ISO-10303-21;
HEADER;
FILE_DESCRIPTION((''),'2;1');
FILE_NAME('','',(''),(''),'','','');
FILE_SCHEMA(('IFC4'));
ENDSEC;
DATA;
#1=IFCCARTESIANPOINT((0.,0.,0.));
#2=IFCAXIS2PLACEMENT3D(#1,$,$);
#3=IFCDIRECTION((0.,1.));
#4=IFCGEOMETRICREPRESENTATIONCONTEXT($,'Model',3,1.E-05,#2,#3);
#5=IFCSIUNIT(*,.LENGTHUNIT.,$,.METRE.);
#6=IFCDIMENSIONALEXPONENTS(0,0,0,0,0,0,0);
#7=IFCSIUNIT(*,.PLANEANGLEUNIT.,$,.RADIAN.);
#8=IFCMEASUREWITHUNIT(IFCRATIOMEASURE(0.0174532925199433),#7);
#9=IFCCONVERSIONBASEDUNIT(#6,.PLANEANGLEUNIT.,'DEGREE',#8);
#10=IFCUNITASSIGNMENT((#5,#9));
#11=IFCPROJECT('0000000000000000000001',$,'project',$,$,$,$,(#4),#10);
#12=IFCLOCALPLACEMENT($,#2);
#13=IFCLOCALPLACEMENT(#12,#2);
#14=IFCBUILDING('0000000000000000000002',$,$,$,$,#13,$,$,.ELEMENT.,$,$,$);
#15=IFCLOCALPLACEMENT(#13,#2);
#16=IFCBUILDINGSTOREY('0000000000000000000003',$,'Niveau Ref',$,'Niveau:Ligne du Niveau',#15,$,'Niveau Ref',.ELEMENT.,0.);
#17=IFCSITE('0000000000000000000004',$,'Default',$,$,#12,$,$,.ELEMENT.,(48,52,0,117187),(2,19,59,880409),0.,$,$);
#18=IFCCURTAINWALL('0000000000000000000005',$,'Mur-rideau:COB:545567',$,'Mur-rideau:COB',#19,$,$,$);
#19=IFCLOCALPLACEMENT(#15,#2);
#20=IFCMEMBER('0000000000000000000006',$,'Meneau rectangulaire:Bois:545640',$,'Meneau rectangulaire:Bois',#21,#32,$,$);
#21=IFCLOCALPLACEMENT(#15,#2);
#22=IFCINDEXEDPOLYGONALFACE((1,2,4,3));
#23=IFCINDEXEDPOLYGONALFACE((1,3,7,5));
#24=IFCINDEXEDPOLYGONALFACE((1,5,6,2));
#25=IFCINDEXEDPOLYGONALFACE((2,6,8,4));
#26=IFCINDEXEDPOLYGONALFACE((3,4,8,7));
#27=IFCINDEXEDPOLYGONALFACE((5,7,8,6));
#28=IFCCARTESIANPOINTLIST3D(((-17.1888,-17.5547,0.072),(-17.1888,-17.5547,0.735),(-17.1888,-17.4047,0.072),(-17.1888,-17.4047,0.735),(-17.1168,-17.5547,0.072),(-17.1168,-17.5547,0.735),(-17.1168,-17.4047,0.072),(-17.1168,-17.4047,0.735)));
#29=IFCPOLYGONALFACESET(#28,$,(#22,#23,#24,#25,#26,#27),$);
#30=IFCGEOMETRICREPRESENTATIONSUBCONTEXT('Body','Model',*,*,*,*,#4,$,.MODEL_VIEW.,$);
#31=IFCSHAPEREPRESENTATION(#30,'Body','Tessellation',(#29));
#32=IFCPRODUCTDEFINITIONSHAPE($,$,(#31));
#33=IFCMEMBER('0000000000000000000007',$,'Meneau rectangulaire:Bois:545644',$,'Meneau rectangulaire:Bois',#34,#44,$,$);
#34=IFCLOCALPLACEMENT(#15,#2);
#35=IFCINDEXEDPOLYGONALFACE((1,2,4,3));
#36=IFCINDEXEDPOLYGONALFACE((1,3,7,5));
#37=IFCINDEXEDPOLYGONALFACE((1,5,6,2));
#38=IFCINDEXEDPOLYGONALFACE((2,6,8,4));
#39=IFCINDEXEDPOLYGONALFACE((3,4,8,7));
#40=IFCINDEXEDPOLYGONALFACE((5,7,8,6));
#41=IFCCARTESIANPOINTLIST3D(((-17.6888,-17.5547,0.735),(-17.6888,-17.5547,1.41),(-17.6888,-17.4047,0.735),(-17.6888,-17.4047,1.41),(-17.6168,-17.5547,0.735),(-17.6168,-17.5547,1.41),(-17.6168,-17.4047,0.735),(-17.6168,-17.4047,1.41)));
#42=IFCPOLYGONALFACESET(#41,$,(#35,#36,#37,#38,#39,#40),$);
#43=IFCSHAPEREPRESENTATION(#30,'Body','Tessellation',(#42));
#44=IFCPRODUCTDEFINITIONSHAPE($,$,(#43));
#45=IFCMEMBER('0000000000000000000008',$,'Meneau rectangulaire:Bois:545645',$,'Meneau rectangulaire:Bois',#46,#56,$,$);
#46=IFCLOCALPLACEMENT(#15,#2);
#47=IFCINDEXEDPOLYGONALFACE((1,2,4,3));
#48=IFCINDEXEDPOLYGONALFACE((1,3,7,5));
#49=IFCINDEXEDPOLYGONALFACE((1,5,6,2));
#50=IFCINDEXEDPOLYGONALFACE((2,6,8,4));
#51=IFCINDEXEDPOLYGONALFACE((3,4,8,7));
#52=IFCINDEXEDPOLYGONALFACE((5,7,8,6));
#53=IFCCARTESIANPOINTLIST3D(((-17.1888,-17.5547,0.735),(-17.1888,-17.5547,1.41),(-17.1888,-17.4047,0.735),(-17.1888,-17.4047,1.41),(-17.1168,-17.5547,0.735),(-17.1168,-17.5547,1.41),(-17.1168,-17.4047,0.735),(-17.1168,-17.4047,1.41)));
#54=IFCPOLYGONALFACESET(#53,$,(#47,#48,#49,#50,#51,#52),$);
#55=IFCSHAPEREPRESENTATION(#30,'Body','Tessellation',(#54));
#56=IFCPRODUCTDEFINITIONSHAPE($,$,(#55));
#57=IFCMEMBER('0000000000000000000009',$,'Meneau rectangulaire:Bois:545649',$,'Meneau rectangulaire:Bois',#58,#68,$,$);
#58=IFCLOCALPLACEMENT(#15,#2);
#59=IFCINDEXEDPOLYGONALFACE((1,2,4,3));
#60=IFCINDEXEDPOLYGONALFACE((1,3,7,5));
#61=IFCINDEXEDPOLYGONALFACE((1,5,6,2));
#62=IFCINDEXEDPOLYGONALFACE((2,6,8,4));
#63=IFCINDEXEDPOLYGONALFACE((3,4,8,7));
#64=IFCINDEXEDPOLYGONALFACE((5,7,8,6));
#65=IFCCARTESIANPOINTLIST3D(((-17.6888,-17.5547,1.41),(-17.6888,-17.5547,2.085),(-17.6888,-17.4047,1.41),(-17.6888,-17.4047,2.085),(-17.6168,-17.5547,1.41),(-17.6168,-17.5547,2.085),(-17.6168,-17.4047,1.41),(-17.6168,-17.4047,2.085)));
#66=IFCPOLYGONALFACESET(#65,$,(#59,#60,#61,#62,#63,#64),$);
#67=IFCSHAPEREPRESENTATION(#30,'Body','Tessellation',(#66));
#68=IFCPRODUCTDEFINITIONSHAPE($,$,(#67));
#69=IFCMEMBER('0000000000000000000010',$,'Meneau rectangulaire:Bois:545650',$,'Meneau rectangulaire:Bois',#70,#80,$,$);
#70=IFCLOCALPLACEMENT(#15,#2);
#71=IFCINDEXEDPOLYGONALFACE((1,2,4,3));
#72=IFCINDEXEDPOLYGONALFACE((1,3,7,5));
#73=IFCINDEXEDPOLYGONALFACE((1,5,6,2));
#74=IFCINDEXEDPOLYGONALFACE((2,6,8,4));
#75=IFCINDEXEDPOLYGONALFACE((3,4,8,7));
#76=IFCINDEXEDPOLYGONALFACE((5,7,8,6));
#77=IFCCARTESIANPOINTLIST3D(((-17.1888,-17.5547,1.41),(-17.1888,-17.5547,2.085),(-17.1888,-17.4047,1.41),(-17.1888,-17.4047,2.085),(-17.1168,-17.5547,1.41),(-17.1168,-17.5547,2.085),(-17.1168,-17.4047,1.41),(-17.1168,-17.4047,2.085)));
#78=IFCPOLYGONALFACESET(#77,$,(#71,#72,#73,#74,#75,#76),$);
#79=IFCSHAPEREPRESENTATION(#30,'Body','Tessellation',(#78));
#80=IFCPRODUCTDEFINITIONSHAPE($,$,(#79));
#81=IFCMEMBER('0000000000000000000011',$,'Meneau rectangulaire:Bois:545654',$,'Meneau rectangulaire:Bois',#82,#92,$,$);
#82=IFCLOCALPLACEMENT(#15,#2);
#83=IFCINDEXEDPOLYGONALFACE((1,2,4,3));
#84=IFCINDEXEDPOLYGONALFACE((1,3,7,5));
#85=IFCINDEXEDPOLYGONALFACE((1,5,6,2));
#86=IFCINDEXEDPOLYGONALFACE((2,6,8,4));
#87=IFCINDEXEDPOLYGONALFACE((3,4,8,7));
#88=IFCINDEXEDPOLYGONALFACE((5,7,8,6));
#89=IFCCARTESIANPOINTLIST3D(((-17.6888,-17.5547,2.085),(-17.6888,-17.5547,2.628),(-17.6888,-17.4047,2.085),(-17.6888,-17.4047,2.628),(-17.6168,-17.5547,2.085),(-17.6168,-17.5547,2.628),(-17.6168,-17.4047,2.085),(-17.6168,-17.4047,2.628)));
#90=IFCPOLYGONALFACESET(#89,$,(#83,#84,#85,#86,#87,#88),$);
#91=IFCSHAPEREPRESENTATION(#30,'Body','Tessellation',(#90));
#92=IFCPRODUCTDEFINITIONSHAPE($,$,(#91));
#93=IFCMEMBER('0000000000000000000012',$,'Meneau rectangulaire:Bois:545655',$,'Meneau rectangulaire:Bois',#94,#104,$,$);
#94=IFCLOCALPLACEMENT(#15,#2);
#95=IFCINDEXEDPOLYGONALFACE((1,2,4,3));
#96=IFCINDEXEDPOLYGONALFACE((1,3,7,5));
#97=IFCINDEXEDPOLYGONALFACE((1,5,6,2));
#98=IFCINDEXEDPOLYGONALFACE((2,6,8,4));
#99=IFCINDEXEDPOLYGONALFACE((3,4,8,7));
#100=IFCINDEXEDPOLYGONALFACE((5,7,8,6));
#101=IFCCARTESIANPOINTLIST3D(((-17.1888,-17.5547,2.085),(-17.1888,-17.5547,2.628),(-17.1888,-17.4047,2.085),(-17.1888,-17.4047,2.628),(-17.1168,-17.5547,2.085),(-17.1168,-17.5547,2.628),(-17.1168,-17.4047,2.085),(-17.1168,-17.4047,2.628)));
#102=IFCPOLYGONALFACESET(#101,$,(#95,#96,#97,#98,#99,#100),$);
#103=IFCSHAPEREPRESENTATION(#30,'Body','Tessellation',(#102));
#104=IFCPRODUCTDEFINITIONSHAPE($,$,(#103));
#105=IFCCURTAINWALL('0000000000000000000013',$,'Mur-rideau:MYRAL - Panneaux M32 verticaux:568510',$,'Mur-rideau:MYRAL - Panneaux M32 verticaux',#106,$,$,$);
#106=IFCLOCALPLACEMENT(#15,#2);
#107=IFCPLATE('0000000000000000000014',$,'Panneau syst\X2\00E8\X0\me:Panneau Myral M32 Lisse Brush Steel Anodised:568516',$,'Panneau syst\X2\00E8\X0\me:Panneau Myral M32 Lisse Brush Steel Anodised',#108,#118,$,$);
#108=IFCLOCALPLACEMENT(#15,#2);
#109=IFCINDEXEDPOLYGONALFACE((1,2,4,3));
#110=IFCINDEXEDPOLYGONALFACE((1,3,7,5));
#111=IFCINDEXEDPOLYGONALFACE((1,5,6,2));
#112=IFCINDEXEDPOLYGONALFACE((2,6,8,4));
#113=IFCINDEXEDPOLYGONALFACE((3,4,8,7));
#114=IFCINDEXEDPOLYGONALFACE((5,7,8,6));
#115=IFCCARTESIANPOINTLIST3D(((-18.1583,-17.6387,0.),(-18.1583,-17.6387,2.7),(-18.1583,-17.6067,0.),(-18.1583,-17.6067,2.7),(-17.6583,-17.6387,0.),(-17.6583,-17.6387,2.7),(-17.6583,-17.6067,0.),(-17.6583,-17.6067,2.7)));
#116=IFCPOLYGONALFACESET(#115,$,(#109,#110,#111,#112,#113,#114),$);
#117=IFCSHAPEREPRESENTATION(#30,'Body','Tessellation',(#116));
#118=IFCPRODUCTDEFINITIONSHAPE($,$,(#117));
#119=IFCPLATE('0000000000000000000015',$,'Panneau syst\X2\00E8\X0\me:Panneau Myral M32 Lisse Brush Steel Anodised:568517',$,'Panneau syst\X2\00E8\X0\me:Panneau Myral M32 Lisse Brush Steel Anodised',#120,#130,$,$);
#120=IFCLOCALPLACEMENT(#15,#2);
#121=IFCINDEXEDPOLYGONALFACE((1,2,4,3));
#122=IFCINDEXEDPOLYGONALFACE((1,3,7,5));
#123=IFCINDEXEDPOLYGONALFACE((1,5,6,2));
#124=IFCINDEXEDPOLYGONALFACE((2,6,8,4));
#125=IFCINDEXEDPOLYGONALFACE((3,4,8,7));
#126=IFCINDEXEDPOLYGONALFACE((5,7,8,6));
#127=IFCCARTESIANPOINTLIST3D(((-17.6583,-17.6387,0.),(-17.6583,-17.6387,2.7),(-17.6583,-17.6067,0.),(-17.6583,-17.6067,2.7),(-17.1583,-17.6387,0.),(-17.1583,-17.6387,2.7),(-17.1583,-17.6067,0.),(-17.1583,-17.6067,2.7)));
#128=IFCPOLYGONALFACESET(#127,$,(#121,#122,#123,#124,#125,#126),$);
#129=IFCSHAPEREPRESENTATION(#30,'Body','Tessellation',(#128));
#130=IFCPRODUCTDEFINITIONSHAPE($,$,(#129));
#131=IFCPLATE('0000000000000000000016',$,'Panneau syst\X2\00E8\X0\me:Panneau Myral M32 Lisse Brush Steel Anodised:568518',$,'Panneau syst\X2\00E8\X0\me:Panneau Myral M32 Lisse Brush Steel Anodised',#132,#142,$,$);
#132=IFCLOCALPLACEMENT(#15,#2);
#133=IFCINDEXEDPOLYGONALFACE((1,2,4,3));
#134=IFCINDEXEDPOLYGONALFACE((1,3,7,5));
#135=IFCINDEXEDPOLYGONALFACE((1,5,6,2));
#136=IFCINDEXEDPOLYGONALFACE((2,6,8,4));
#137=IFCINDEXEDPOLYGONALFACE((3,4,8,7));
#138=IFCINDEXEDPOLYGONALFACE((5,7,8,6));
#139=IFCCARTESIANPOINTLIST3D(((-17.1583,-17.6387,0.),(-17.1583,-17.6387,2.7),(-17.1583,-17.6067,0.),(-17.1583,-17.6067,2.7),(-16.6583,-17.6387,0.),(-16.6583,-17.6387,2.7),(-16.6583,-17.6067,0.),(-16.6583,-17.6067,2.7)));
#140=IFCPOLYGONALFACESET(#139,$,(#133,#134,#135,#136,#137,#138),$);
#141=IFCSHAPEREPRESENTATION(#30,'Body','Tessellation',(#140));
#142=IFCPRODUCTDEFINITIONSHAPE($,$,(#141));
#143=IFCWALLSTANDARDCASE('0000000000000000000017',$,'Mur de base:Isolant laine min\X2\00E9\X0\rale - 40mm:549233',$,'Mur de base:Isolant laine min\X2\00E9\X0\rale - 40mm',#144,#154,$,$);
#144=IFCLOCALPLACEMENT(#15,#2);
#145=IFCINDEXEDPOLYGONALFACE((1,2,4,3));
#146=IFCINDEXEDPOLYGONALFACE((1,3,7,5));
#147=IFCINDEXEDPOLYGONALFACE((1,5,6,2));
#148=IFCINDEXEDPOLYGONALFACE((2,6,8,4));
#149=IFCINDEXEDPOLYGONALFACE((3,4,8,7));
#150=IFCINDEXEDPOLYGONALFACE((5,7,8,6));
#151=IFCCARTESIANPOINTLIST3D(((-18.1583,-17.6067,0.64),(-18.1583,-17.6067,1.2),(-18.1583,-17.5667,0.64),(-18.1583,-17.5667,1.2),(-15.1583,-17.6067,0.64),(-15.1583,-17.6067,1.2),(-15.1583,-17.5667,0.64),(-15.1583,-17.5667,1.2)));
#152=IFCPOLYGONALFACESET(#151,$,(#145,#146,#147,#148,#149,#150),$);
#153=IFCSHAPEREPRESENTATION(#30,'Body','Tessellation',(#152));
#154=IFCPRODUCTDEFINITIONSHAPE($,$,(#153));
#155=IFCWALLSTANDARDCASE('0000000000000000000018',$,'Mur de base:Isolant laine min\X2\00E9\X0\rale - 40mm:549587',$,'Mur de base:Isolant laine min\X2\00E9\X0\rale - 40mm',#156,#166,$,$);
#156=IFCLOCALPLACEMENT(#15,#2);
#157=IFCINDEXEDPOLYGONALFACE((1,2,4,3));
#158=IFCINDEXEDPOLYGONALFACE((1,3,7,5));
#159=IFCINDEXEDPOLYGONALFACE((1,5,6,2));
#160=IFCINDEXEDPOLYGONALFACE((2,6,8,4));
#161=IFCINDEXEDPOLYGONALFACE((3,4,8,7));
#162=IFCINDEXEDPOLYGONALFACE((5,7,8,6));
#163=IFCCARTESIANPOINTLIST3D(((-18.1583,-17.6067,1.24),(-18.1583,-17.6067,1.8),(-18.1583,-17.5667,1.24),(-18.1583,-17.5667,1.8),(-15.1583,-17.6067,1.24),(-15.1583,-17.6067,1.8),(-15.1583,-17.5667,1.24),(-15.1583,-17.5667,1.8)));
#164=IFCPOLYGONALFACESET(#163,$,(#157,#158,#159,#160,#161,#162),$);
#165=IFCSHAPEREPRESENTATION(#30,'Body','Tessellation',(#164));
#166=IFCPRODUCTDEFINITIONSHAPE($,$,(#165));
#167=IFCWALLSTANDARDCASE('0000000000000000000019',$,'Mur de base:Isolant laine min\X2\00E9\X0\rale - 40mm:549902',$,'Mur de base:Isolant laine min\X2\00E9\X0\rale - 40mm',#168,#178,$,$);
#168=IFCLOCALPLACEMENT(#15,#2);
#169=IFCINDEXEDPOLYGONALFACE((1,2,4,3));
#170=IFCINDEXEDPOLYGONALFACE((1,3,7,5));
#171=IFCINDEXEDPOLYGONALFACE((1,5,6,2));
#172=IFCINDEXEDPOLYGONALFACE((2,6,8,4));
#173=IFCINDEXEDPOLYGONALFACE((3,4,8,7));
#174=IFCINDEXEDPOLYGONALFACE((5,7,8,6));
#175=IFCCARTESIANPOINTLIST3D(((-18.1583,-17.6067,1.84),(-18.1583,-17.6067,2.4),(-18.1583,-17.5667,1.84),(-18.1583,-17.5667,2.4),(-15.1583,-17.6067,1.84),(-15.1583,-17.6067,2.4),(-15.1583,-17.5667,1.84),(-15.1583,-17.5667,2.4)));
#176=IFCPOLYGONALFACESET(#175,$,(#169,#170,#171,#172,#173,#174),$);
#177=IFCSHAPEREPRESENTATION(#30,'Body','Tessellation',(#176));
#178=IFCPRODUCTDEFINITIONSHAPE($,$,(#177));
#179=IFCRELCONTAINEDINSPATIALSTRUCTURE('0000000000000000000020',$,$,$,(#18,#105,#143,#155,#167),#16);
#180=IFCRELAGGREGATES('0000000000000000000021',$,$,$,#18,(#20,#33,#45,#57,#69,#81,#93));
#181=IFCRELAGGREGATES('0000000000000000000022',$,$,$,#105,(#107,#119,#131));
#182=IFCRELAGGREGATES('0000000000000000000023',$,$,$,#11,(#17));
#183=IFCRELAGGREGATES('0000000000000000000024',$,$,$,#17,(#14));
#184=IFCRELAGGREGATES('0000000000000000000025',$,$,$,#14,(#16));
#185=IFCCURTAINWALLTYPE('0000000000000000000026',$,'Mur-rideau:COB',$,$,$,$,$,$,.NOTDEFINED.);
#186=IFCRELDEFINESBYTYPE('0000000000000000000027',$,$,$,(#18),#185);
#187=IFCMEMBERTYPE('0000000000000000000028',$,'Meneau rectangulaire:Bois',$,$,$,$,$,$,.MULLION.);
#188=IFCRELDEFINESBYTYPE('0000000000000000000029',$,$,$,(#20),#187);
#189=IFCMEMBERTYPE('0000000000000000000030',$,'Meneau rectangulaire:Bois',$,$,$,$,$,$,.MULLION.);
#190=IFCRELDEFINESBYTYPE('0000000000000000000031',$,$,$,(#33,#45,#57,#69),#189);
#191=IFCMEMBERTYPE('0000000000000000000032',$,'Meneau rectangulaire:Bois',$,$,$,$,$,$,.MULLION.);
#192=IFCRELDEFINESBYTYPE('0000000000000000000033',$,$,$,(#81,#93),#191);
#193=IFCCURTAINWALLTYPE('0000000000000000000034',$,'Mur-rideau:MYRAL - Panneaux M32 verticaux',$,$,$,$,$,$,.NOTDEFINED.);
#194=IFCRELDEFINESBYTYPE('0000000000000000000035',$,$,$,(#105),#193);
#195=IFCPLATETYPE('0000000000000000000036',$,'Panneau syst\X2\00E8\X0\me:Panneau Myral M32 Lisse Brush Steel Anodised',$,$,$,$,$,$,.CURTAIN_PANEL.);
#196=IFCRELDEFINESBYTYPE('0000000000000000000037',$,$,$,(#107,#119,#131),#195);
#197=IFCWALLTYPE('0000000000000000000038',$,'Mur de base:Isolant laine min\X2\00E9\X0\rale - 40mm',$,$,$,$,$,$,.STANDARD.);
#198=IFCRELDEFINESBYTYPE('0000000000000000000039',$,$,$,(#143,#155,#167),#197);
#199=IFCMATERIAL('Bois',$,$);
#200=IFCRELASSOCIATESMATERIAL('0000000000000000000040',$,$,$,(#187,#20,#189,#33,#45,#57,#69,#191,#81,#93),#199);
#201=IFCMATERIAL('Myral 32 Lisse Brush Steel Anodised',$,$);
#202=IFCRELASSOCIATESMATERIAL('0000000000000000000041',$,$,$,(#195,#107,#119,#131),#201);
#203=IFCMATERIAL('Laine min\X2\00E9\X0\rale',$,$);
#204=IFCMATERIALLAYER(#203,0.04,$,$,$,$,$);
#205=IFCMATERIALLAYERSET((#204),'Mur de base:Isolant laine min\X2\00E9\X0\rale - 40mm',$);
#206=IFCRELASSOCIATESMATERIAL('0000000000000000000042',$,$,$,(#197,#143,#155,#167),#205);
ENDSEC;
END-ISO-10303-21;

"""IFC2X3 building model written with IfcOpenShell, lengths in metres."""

from ifc_helpers import new_model, entity, si_unit, converted_unit, direction, frame, frame_2d, origin, origin_2d_with_axis, place, context, subcontext, project, spatial, rectangle, extrude, source, transform, mapped, material, layer, layer_set, layer_usage, type_object, type_shapes, element, aggregate, save


model = new_model("IFC2X3")

# Units and contexts
model_context = context("Model", 3, precision=1e-05, world=origin(), true_north=direction((0.0, 1.0)))
body_context = subcontext(model_context, "Body", "Model", "MODEL_VIEW")
ifc_project = project(units=[si_unit("LENGTHUNIT", "METRE"), converted_unit("PLANEANGLEUNIT", "DEGREE", entity("IfcRatioMeasure", 0.0174532925199433), si_unit("PLANEANGLEUNIT", "RADIAN"), dimensions=[0, 0, 0, 0, 0, 0, 0])], contexts=[model_context])

# Site, building, storey
site_placement = place(None, origin())
site = spatial("IfcSite", under=ifc_project, at=site_placement, Name="Default", CompositionType="ELEMENT", RefLatitude=(48, 52, 0, 117187), RefLongitude=(2, 19, 59, 880409), RefElevation=0.0)
building_placement = place(site_placement, origin())
building = spatial("IfcBuilding", under=site, at=building_placement, CompositionType="ELEMENT")
storey_placement = place(building_placement, origin())
storey = spatial("IfcBuildingStorey", under=building, at=storey_placement, Name="Niveau Ref", ObjectType="Niveau:Ligne du Niveau", LongName="Niveau Ref", CompositionType="ELEMENT", Elevation=0.0)

# Curtain wall, members
curtain_wall_type_1 = type_object("IfcCurtainWallType", Name="Mur-rideau:COB", PredefinedType="NOTDEFINED")
curtain_wall_1_placement = place(storey_placement, origin())
curtain_wall_1 = element("IfcCurtainWall", 1, at=curtain_wall_1_placement, inside=storey, type_object=curtain_wall_type_1, Name="Mur-rideau:COB:545567", ObjectType="Mur-rideau:COB")
ifc_material_1 = material(Name="Bois")
member_type_1 = type_object("IfcMemberType", Name="Meneau rectangulaire:Bois", PredefinedType="MULLION", material=ifc_material_1)
shared_shape_1 = source(origin(), body_context, "Body", "SweptSolid", [
    extrude(rectangle(XDim=0.15, YDim=0.072, at=origin_2d_with_axis()), frame((-0.024, 0.0, -0.663), z_axis=(0.0, 0.0, 1.0), x_axis=(0.0, -1.0, 0.0)), (0.0, 0.0, 1.0), 0.663),
])
type_shapes(member_type_1, [shared_shape_1])
member_1_placement = place(storey_placement, frame((-17.1288, -17.4797, 0.072), z_axis=(0.0, 0.0, -1.0), x_axis=(1.0, 0.0, 0.0)))
member_1 = element("IfcMember", 2, at=member_1_placement, type_object=member_type_1, material=ifc_material_1, Name="Meneau rectangulaire:Bois:545640", ObjectType="Meneau rectangulaire:Bois", context=body_context, shape_type="MappedRepresentation", body=[
    mapped(shared_shape_1, transform((0.0, 0.0, 0.0), scale=1.0)),
])
member_type_2 = type_object("IfcMemberType", Name="Meneau rectangulaire:Bois", PredefinedType="MULLION", material=ifc_material_1)
shared_shape_2 = source(origin(), body_context, "Body", "SweptSolid", [
    extrude(rectangle(XDim=0.15, YDim=0.072, at=origin_2d_with_axis()), frame((-0.024, 0.0, -0.675), z_axis=(0.0, 0.0, 1.0), x_axis=(0.0, -1.0, 0.0)), (0.0, 0.0, 1.0), 0.675),
])
type_shapes(member_type_2, [shared_shape_2])
member_2_placement = place(storey_placement, frame((-17.6288, -17.4797, 0.735), z_axis=(0.0, 0.0, -1.0), x_axis=(1.0, 0.0, 0.0)))
member_2 = element("IfcMember", 3, at=member_2_placement, type_object=member_type_2, material=ifc_material_1, Name="Meneau rectangulaire:Bois:545644", ObjectType="Meneau rectangulaire:Bois", context=body_context, shape_type="MappedRepresentation", body=[
    mapped(shared_shape_2, transform((0.0, 0.0, 0.0), scale=1.0)),
])
member_3_placement = place(storey_placement, frame((-17.1288, -17.4797, 0.735), z_axis=(0.0, 0.0, -1.0), x_axis=(1.0, 0.0, 0.0)))
member_3 = element("IfcMember", 4, at=member_3_placement, type_object=member_type_2, material=ifc_material_1, Name="Meneau rectangulaire:Bois:545645", ObjectType="Meneau rectangulaire:Bois", context=body_context, shape_type="MappedRepresentation", body=[
    mapped(shared_shape_2, transform((0.0, 0.0, 0.0), scale=1.0)),
])
member_4_placement = place(storey_placement, frame((-17.6288, -17.4797, 1.41), z_axis=(0.0, 0.0, -1.0), x_axis=(1.0, 0.0, 0.0)))
member_4 = element("IfcMember", 5, at=member_4_placement, type_object=member_type_2, material=ifc_material_1, Name="Meneau rectangulaire:Bois:545649", ObjectType="Meneau rectangulaire:Bois", context=body_context, shape_type="MappedRepresentation", body=[
    mapped(shared_shape_2, transform((0.0, 0.0, 0.0), scale=1.0)),
])
member_5_placement = place(storey_placement, frame((-17.1288, -17.4797, 1.41), z_axis=(0.0, 0.0, -1.0), x_axis=(1.0, 0.0, 0.0)))
member_5 = element("IfcMember", 6, at=member_5_placement, type_object=member_type_2, material=ifc_material_1, Name="Meneau rectangulaire:Bois:545650", ObjectType="Meneau rectangulaire:Bois", context=body_context, shape_type="MappedRepresentation", body=[
    mapped(shared_shape_2, transform((0.0, 0.0, 0.0), scale=1.0)),
])
member_type_3 = type_object("IfcMemberType", Name="Meneau rectangulaire:Bois", PredefinedType="MULLION", material=ifc_material_1)
shared_shape_3 = source(origin(), body_context, "Body", "SweptSolid", [
    extrude(rectangle(XDim=0.15, YDim=0.072, at=origin_2d_with_axis()), frame((-0.024, 0.0, -0.543), z_axis=(0.0, 0.0, 1.0), x_axis=(0.0, -1.0, 0.0)), (0.0, 0.0, 1.0), 0.543),
])
type_shapes(member_type_3, [shared_shape_3])
member_6_placement = place(storey_placement, frame((-17.6288, -17.4797, 2.085), z_axis=(0.0, 0.0, -1.0), x_axis=(1.0, 0.0, 0.0)))
member_6 = element("IfcMember", 7, at=member_6_placement, type_object=member_type_3, material=ifc_material_1, Name="Meneau rectangulaire:Bois:545654", ObjectType="Meneau rectangulaire:Bois", context=body_context, shape_type="MappedRepresentation", body=[
    mapped(shared_shape_3, transform((0.0, 0.0, 0.0), scale=1.0)),
])
member_7_placement = place(storey_placement, frame((-17.1288, -17.4797, 2.085), z_axis=(0.0, 0.0, -1.0), x_axis=(1.0, 0.0, 0.0)))
member_7 = element("IfcMember", 8, at=member_7_placement, type_object=member_type_3, material=ifc_material_1, Name="Meneau rectangulaire:Bois:545655", ObjectType="Meneau rectangulaire:Bois", context=body_context, shape_type="MappedRepresentation", body=[
    mapped(shared_shape_3, transform((0.0, 0.0, 0.0), scale=1.0)),
])
aggregate(curtain_wall_1, [member_1, member_2, member_3, member_4, member_5, member_6, member_7])

# Curtain wall, plates
curtain_wall_type_2 = type_object("IfcCurtainWallType", Name="Mur-rideau:MYRAL - Panneaux M32 verticaux", PredefinedType="NOTDEFINED")
curtain_wall_2_placement = place(storey_placement, origin())
curtain_wall_2 = element("IfcCurtainWall", 9, at=curtain_wall_2_placement, inside=storey, type_object=curtain_wall_type_2, Name="Mur-rideau:MYRAL - Panneaux M32 verticaux:568510", ObjectType="Mur-rideau:MYRAL - Panneaux M32 verticaux")
ifc_material_2 = material(Name="Myral 32 Lisse Brush Steel Anodised")
plate_type = type_object("IfcPlateType", Name="Panneau système:Panneau Myral M32 Lisse Brush Steel Anodised", PredefinedType="CURTAIN_PANEL", material=ifc_material_2)
shared_shape_4 = source(origin(), body_context, "Body", "SweptSolid", [
    extrude(rectangle(XDim=0.032, YDim=0.5, at=origin_2d_with_axis()), frame((0.0, -0.016, 0.0), z_axis=(0.0, 0.0, 1.0), x_axis=(0.0, 1.0, 0.0)), (0.0, 0.0, 1.0), 2.7),
])
type_shapes(plate_type, [shared_shape_4])
plate_1_placement = place(curtain_wall_2_placement, frame((-17.9083, -17.6067, 0.0)))
plate_1 = element("IfcPlate", 10, at=plate_1_placement, type_object=plate_type, material=ifc_material_2, Name="Panneau système:Panneau Myral M32 Lisse Brush Steel Anodised:568516", ObjectType="Panneau système:Panneau Myral M32 Lisse Brush Steel Anodised", context=body_context, shape_type="MappedRepresentation", body=[
    mapped(shared_shape_4, transform((0.0, 0.0, 0.0), scale=1.0)),
])
plate_2_placement = place(curtain_wall_2_placement, frame((-17.4083, -17.6067, 0.0)))
plate_2 = element("IfcPlate", 11, at=plate_2_placement, type_object=plate_type, material=ifc_material_2, Name="Panneau système:Panneau Myral M32 Lisse Brush Steel Anodised:568517", ObjectType="Panneau système:Panneau Myral M32 Lisse Brush Steel Anodised", context=body_context, shape_type="MappedRepresentation", body=[
    mapped(shared_shape_4, transform((0.0, 0.0, 0.0), scale=1.0)),
])
plate_3_placement = place(curtain_wall_2_placement, frame((-16.9083, -17.6067, 0.0)))
plate_3 = element("IfcPlate", 12, at=plate_3_placement, type_object=plate_type, material=ifc_material_2, Name="Panneau système:Panneau Myral M32 Lisse Brush Steel Anodised:568518", ObjectType="Panneau système:Panneau Myral M32 Lisse Brush Steel Anodised", context=body_context, shape_type="MappedRepresentation", body=[
    mapped(shared_shape_4, transform((0.0, 0.0, 0.0), scale=1.0)),
])
aggregate(curtain_wall_2, [plate_1, plate_2, plate_3])

# Walls
ifc_material_3 = material(Name="Laine minérale")
ifc_layer = layer(ifc_material_3, 0.04)
ifc_layer_set = layer_set([ifc_layer], Name="Mur de base:Isolant laine minérale - 40mm")
ifc_layer_usage_1 = layer_usage(ifc_layer_set, "AXIS2", "NEGATIVE", 0.02)
wall_type = type_object("IfcWallType", Name="Mur de base:Isolant laine minérale - 40mm", PredefinedType="STANDARD", material=ifc_layer_set)
wall_1_placement = place(storey_placement, frame((-18.1583, -17.5867, 0.64)))
element("IfcWallStandardCase", 13, at=wall_1_placement, inside=storey, type_object=wall_type, material=ifc_layer_usage_1, Name="Mur de base:Isolant laine minérale - 40mm:549233", ObjectType="Mur de base:Isolant laine minérale - 40mm", context=body_context, shape_type="SweptSolid", body=[
    extrude(rectangle(XDim=3.0, YDim=0.04, at=frame_2d((1.5, 0.0), x_axis=(-1.0, 0.0))), origin(), (0.0, 0.0, 1.0), 0.56),
])
ifc_layer_usage_2 = layer_usage(ifc_layer_set, "AXIS2", "NEGATIVE", 0.02)
wall_2_placement = place(storey_placement, frame((-18.1583, -17.5867, 1.24)))
element("IfcWallStandardCase", 14, at=wall_2_placement, inside=storey, type_object=wall_type, material=ifc_layer_usage_2, Name="Mur de base:Isolant laine minérale - 40mm:549587", ObjectType="Mur de base:Isolant laine minérale - 40mm", context=body_context, shape_type="SweptSolid", body=[
    extrude(rectangle(XDim=3.0, YDim=0.04, at=frame_2d((1.5, 0.0), x_axis=(-1.0, 0.0))), origin(), (0.0, 0.0, 1.0), 0.56),
])
ifc_layer_usage_3 = layer_usage(ifc_layer_set, "AXIS2", "NEGATIVE", 0.02)
wall_3_placement = place(storey_placement, frame((-18.1583, -17.5867, 1.84)))
element("IfcWallStandardCase", 15, at=wall_3_placement, inside=storey, type_object=wall_type, material=ifc_layer_usage_3, Name="Mur de base:Isolant laine minérale - 40mm:549902", ObjectType="Mur de base:Isolant laine minérale - 40mm", context=body_context, shape_type="SweptSolid", body=[
    extrude(rectangle(XDim=3.0, YDim=0.04, at=frame_2d((1.5, 0.0), x_axis=(-1.0, 0.0))), origin(), (0.0, 0.0, 1.0), 0.56),
])

save(model, "model.ifc")
